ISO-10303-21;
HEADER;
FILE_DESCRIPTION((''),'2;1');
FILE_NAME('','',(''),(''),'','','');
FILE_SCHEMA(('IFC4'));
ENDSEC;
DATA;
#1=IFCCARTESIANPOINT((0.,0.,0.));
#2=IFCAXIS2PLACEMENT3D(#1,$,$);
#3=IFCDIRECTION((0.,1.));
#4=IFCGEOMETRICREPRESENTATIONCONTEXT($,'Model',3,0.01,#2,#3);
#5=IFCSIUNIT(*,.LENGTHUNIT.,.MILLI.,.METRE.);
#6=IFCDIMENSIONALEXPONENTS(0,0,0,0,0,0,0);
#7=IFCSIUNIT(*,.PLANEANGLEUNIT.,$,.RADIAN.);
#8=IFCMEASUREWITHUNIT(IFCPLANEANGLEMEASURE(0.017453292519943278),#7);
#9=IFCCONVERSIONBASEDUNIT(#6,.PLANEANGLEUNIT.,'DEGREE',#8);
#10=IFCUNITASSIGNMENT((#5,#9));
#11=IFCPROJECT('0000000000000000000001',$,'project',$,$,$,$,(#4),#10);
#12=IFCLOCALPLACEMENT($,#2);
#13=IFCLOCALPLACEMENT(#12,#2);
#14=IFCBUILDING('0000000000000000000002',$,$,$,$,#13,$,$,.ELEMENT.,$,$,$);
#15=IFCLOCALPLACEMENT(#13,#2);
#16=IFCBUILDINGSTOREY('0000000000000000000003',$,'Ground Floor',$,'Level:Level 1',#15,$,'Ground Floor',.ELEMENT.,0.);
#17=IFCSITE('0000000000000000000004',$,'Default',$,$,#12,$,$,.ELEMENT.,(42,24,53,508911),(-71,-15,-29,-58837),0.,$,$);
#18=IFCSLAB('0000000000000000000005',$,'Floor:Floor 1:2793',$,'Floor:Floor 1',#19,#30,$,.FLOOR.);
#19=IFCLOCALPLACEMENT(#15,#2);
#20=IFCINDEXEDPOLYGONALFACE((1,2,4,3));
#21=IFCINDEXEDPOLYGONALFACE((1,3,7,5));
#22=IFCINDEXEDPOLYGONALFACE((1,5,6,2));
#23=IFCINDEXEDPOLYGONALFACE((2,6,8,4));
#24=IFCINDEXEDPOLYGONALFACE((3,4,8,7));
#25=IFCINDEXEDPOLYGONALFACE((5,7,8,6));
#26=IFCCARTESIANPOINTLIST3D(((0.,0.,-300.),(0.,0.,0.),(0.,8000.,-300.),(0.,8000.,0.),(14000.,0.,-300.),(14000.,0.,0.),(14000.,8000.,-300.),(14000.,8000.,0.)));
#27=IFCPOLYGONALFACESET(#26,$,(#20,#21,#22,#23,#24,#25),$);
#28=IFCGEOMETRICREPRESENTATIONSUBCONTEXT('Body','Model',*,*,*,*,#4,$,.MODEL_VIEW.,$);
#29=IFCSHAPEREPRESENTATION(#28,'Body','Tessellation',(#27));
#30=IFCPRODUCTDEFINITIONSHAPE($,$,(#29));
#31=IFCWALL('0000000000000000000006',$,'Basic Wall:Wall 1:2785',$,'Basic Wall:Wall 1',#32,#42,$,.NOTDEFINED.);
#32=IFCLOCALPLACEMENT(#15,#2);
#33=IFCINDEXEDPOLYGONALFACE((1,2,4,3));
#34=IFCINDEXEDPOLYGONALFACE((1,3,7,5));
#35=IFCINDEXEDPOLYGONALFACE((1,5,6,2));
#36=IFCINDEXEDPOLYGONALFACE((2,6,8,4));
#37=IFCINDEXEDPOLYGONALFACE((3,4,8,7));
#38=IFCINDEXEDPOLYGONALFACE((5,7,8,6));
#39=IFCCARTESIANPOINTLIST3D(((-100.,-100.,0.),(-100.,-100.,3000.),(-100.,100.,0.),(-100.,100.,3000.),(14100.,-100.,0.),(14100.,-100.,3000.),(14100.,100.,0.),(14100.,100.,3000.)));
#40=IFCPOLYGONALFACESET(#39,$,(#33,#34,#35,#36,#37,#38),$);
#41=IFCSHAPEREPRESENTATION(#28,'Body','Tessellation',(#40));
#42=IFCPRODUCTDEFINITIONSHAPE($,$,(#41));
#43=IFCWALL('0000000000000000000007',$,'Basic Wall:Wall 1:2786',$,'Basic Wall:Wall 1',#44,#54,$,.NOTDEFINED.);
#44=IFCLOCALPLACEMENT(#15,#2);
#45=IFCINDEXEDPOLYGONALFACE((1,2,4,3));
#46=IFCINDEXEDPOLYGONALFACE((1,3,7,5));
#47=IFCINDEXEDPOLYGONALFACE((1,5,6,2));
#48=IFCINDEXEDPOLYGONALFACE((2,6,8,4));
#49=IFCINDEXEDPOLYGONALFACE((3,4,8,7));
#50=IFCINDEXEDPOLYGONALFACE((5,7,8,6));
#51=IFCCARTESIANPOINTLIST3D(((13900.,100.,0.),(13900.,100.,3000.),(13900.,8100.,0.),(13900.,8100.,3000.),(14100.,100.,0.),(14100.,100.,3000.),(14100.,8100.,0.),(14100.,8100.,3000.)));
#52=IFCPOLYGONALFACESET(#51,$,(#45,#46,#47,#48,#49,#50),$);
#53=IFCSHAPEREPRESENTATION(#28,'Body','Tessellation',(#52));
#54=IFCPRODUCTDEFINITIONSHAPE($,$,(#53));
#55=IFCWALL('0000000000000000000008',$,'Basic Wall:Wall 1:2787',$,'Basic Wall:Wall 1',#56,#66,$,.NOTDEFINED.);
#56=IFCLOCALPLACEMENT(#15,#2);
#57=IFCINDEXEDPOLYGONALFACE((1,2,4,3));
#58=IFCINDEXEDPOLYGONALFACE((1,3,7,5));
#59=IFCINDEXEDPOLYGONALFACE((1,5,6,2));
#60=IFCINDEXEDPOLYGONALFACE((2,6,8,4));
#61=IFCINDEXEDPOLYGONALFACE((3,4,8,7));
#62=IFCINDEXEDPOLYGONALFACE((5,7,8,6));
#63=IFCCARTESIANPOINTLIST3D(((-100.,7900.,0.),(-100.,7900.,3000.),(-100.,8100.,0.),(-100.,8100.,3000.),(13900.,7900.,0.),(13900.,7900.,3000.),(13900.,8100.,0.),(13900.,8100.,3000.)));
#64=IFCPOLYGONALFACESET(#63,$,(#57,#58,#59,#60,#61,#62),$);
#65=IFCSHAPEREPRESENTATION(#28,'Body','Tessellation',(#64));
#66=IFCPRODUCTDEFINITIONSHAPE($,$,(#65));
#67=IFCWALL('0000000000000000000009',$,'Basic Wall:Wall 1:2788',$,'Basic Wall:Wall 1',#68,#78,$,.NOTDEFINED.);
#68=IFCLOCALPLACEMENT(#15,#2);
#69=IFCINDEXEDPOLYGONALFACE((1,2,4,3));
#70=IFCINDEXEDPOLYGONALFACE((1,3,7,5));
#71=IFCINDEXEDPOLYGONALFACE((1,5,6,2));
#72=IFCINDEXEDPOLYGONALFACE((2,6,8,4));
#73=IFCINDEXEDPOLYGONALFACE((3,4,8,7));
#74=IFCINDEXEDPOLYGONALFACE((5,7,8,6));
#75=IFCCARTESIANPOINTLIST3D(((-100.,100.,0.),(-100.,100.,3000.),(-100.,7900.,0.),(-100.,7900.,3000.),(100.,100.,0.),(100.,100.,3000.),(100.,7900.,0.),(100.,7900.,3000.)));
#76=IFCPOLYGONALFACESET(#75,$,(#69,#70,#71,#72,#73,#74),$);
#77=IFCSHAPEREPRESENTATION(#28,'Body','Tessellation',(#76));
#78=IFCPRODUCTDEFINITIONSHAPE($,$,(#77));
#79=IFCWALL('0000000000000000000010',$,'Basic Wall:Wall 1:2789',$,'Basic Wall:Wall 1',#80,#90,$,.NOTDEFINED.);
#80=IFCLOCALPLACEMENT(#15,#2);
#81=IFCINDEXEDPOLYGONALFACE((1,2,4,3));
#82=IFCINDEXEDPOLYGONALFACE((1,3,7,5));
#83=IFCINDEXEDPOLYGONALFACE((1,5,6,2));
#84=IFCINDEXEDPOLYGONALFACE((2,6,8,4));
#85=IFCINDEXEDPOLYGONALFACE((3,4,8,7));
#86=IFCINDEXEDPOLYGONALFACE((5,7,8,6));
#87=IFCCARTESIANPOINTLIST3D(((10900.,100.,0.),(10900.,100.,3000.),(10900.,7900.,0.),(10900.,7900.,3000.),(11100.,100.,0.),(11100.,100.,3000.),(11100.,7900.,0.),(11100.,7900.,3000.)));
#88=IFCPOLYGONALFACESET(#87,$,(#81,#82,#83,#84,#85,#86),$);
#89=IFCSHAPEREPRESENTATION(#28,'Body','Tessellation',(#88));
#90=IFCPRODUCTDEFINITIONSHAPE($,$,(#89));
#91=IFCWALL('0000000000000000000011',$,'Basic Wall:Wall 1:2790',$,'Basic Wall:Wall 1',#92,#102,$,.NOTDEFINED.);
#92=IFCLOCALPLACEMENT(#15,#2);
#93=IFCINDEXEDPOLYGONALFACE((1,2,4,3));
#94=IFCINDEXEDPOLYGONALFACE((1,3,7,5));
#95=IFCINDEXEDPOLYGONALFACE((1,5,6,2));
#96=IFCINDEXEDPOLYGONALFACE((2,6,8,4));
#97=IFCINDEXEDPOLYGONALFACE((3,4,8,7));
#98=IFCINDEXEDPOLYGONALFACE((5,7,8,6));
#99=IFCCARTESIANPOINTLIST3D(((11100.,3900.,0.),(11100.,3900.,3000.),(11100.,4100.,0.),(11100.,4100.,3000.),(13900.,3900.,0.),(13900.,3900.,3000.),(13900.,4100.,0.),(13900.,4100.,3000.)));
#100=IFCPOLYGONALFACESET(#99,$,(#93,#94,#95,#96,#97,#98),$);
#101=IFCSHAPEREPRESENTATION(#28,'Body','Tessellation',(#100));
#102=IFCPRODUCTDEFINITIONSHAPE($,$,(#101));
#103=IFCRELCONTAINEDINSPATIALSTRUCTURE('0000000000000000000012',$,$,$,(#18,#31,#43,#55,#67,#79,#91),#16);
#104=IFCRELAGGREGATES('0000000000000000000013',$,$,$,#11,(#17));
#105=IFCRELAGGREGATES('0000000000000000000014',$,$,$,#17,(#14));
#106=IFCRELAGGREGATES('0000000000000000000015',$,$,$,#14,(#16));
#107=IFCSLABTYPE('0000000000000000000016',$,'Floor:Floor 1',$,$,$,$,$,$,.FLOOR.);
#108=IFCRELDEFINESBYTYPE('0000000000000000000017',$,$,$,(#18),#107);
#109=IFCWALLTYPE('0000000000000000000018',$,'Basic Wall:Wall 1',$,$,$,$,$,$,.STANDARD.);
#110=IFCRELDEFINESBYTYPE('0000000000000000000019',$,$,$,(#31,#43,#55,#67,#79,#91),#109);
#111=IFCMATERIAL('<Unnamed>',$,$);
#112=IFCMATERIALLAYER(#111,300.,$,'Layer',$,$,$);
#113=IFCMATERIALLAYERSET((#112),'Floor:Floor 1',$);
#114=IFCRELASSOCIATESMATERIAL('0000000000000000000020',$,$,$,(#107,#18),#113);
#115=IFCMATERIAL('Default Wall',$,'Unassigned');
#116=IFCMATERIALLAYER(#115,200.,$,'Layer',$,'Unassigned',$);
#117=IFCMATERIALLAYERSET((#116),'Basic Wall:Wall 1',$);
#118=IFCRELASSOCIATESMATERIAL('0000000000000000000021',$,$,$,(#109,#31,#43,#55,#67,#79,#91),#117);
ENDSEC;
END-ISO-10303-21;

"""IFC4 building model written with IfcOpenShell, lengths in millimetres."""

from ifc_helpers import new_model, entity, si_unit, converted_unit, direction, frame, frame_2d, origin, origin_2d_with_axis, place, context, subcontext, project, spatial, rectangle, extrude, material, layer, layer_set, layer_usage, type_object, element, save


model = new_model("IFC4")

# Units and contexts
model_context = context("Model", 3, precision=0.01, world=origin(), true_north=direction((0.0, 1.0)))
body_context = subcontext(model_context, "Body", "Model", "MODEL_VIEW")
ifc_project = project(units=[si_unit("LENGTHUNIT", "METRE", prefix="MILLI"), converted_unit("PLANEANGLEUNIT", "DEGREE", entity("IfcPlaneAngleMeasure", 0.017453292519943278), si_unit("PLANEANGLEUNIT", "RADIAN"), dimensions=[0, 0, 0, 0, 0, 0, 0])], contexts=[model_context])

# Site, building, storey
site_placement = place(None, origin())
site = spatial("IfcSite", under=ifc_project, at=site_placement, Name="Default", CompositionType="ELEMENT", RefLatitude=(42, 24, 53, 508911), RefLongitude=(-71, -15, -29, -58837), RefElevation=0.0)
building_placement = place(site_placement, origin())
building = spatial("IfcBuilding", under=site, at=building_placement, CompositionType="ELEMENT")
storey_placement = place(building_placement, origin())
storey = spatial("IfcBuildingStorey", under=building, at=storey_placement, Name="Ground Floor", ObjectType="Level:Level 1", LongName="Ground Floor", CompositionType="ELEMENT", Elevation=0.0)

# Shared definitions
ifc_material_1 = material(Name="Default Wall", Category="Unassigned")

# Slab
ifc_material_2 = material(Name="<Unnamed>")
ifc_layer_1 = layer(ifc_material_2, 300.0, Name="Layer")
ifc_layer_set_1 = layer_set([ifc_layer_1], Name="Floor:Floor 1")
ifc_layer_usage_1 = layer_usage(ifc_layer_set_1, "AXIS3", "POSITIVE", 0.0)
slab_type = type_object("IfcSlabType", Name="Floor:Floor 1", PredefinedType="FLOOR", material=ifc_layer_set_1)
slab_placement = place(storey_placement, origin())
element("IfcSlab", 1, at=slab_placement, inside=storey, type_object=slab_type, material=ifc_layer_usage_1, Name="Floor:Floor 1:2793", ObjectType="Floor:Floor 1", PredefinedType="FLOOR", context=body_context, shape_type="SweptSolid", body=[
    extrude(rectangle(XDim=8000.0, YDim=14000.0, at=origin_2d_with_axis()), frame((7000.0, 4000.0, 0.0), z_axis=(0.0, 0.0, -1.0), x_axis=(0.0, 1.0, 0.0)), (0.0, 0.0, 1.0), 300.0),
])

# Walls
ifc_layer_2 = layer(ifc_material_1, 200.0, Name="Layer", Category="Unassigned")
ifc_layer_set_2 = layer_set([ifc_layer_2], Name="Basic Wall:Wall 1")
ifc_layer_usage_2 = layer_usage(ifc_layer_set_2, "AXIS2", "NEGATIVE", 100.0)
wall_type = type_object("IfcWallType", Name="Basic Wall:Wall 1", PredefinedType="STANDARD", material=ifc_layer_set_2)
wall_1_placement = place(storey_placement, frame((-100.0, 0.0, 0.0)))
element("IfcWall", 2, at=wall_1_placement, inside=storey, type_object=wall_type, material=ifc_layer_usage_2, Name="Basic Wall:Wall 1:2785", ObjectType="Basic Wall:Wall 1", PredefinedType="NOTDEFINED", context=body_context, shape_type="SweptSolid", body=[
    extrude(rectangle(XDim=14200.0, YDim=200.0, at=frame_2d((7100.0, 0.0), x_axis=(-1.0, 0.0))), origin(), (0.0, 0.0, 1.0), 3000.0),
])
ifc_layer_usage_3 = layer_usage(ifc_layer_set_2, "AXIS2", "NEGATIVE", 100.0)
wall_2_placement = place(storey_placement, frame((14000.0, 100.0, 0.0), z_axis=(0.0, 0.0, 1.0), x_axis=(0.0, 1.0, 0.0)))
element("IfcWall", 3, at=wall_2_placement, inside=storey, type_object=wall_type, material=ifc_layer_usage_3, Name="Basic Wall:Wall 1:2786", ObjectType="Basic Wall:Wall 1", PredefinedType="NOTDEFINED", context=body_context, shape_type="SweptSolid", body=[
    extrude(rectangle(XDim=8000.0, YDim=200.0, at=frame_2d((4000.0, 0.0), x_axis=(-1.0, 0.0))), origin(), (0.0, 0.0, 1.0), 3000.0),
])
ifc_layer_usage_4 = layer_usage(ifc_layer_set_2, "AXIS2", "NEGATIVE", 100.0)
wall_3_placement = place(storey_placement, frame((13900.0, 8000.0, 0.0), z_axis=(0.0, 0.0, 1.0), x_axis=(-1.0, 0.0, 0.0)))
element("IfcWall", 4, at=wall_3_placement, inside=storey, type_object=wall_type, material=ifc_layer_usage_4, Name="Basic Wall:Wall 1:2787", ObjectType="Basic Wall:Wall 1", PredefinedType="NOTDEFINED", context=body_context, shape_type="SweptSolid", body=[
    extrude(rectangle(XDim=14000.0, YDim=200.0, at=frame_2d((7000.0, 0.0), x_axis=(-1.0, 0.0))), origin(), (0.0, 0.0, 1.0), 3000.0),
])
ifc_layer_usage_5 = layer_usage(ifc_layer_set_2, "AXIS2", "NEGATIVE", 100.0)
wall_4_placement = place(storey_placement, frame((0.0, 7900.0, 0.0), z_axis=(0.0, 0.0, 1.0), x_axis=(0.0, -1.0, 0.0)))
element("IfcWall", 5, at=wall_4_placement, inside=storey, type_object=wall_type, material=ifc_layer_usage_5, Name="Basic Wall:Wall 1:2788", ObjectType="Basic Wall:Wall 1", PredefinedType="NOTDEFINED", context=body_context, shape_type="SweptSolid", body=[
    extrude(rectangle(XDim=7800.0, YDim=200.0, at=frame_2d((3900.0, 0.0), x_axis=(-1.0, 0.0))), origin(), (0.0, 0.0, 1.0), 3000.0),
])
ifc_layer_usage_6 = layer_usage(ifc_layer_set_2, "AXIS2", "NEGATIVE", 100.0)
wall_5_placement = place(storey_placement, frame((11000.0, 100.0, 0.0), z_axis=(0.0, 0.0, 1.0), x_axis=(0.0, 1.0, 0.0)))
element("IfcWall", 6, at=wall_5_placement, inside=storey, type_object=wall_type, material=ifc_layer_usage_6, Name="Basic Wall:Wall 1:2789", ObjectType="Basic Wall:Wall 1", PredefinedType="NOTDEFINED", context=body_context, shape_type="SweptSolid", body=[
    extrude(rectangle(XDim=7800.0, YDim=200.0, at=frame_2d((3900.0, 0.0), x_axis=(-1.0, 0.0))), origin(), (0.0, 0.0, 1.0), 3000.0),
])
ifc_layer_usage_7 = layer_usage(ifc_layer_set_2, "AXIS2", "NEGATIVE", 100.0)
wall_6_placement = place(storey_placement, frame((11100.0, 4000.0, 0.0)))
element("IfcWall", 7, at=wall_6_placement, inside=storey, type_object=wall_type, material=ifc_layer_usage_7, Name="Basic Wall:Wall 1:2790", ObjectType="Basic Wall:Wall 1", PredefinedType="NOTDEFINED", context=body_context, shape_type="SweptSolid", body=[
    extrude(rectangle(XDim=2800.0, YDim=200.0, at=frame_2d((1400.0, 0.0), x_axis=(-1.0, 0.0))), origin(), (0.0, 0.0, 1.0), 3000.0),
])

save(model, "model.ifc")
